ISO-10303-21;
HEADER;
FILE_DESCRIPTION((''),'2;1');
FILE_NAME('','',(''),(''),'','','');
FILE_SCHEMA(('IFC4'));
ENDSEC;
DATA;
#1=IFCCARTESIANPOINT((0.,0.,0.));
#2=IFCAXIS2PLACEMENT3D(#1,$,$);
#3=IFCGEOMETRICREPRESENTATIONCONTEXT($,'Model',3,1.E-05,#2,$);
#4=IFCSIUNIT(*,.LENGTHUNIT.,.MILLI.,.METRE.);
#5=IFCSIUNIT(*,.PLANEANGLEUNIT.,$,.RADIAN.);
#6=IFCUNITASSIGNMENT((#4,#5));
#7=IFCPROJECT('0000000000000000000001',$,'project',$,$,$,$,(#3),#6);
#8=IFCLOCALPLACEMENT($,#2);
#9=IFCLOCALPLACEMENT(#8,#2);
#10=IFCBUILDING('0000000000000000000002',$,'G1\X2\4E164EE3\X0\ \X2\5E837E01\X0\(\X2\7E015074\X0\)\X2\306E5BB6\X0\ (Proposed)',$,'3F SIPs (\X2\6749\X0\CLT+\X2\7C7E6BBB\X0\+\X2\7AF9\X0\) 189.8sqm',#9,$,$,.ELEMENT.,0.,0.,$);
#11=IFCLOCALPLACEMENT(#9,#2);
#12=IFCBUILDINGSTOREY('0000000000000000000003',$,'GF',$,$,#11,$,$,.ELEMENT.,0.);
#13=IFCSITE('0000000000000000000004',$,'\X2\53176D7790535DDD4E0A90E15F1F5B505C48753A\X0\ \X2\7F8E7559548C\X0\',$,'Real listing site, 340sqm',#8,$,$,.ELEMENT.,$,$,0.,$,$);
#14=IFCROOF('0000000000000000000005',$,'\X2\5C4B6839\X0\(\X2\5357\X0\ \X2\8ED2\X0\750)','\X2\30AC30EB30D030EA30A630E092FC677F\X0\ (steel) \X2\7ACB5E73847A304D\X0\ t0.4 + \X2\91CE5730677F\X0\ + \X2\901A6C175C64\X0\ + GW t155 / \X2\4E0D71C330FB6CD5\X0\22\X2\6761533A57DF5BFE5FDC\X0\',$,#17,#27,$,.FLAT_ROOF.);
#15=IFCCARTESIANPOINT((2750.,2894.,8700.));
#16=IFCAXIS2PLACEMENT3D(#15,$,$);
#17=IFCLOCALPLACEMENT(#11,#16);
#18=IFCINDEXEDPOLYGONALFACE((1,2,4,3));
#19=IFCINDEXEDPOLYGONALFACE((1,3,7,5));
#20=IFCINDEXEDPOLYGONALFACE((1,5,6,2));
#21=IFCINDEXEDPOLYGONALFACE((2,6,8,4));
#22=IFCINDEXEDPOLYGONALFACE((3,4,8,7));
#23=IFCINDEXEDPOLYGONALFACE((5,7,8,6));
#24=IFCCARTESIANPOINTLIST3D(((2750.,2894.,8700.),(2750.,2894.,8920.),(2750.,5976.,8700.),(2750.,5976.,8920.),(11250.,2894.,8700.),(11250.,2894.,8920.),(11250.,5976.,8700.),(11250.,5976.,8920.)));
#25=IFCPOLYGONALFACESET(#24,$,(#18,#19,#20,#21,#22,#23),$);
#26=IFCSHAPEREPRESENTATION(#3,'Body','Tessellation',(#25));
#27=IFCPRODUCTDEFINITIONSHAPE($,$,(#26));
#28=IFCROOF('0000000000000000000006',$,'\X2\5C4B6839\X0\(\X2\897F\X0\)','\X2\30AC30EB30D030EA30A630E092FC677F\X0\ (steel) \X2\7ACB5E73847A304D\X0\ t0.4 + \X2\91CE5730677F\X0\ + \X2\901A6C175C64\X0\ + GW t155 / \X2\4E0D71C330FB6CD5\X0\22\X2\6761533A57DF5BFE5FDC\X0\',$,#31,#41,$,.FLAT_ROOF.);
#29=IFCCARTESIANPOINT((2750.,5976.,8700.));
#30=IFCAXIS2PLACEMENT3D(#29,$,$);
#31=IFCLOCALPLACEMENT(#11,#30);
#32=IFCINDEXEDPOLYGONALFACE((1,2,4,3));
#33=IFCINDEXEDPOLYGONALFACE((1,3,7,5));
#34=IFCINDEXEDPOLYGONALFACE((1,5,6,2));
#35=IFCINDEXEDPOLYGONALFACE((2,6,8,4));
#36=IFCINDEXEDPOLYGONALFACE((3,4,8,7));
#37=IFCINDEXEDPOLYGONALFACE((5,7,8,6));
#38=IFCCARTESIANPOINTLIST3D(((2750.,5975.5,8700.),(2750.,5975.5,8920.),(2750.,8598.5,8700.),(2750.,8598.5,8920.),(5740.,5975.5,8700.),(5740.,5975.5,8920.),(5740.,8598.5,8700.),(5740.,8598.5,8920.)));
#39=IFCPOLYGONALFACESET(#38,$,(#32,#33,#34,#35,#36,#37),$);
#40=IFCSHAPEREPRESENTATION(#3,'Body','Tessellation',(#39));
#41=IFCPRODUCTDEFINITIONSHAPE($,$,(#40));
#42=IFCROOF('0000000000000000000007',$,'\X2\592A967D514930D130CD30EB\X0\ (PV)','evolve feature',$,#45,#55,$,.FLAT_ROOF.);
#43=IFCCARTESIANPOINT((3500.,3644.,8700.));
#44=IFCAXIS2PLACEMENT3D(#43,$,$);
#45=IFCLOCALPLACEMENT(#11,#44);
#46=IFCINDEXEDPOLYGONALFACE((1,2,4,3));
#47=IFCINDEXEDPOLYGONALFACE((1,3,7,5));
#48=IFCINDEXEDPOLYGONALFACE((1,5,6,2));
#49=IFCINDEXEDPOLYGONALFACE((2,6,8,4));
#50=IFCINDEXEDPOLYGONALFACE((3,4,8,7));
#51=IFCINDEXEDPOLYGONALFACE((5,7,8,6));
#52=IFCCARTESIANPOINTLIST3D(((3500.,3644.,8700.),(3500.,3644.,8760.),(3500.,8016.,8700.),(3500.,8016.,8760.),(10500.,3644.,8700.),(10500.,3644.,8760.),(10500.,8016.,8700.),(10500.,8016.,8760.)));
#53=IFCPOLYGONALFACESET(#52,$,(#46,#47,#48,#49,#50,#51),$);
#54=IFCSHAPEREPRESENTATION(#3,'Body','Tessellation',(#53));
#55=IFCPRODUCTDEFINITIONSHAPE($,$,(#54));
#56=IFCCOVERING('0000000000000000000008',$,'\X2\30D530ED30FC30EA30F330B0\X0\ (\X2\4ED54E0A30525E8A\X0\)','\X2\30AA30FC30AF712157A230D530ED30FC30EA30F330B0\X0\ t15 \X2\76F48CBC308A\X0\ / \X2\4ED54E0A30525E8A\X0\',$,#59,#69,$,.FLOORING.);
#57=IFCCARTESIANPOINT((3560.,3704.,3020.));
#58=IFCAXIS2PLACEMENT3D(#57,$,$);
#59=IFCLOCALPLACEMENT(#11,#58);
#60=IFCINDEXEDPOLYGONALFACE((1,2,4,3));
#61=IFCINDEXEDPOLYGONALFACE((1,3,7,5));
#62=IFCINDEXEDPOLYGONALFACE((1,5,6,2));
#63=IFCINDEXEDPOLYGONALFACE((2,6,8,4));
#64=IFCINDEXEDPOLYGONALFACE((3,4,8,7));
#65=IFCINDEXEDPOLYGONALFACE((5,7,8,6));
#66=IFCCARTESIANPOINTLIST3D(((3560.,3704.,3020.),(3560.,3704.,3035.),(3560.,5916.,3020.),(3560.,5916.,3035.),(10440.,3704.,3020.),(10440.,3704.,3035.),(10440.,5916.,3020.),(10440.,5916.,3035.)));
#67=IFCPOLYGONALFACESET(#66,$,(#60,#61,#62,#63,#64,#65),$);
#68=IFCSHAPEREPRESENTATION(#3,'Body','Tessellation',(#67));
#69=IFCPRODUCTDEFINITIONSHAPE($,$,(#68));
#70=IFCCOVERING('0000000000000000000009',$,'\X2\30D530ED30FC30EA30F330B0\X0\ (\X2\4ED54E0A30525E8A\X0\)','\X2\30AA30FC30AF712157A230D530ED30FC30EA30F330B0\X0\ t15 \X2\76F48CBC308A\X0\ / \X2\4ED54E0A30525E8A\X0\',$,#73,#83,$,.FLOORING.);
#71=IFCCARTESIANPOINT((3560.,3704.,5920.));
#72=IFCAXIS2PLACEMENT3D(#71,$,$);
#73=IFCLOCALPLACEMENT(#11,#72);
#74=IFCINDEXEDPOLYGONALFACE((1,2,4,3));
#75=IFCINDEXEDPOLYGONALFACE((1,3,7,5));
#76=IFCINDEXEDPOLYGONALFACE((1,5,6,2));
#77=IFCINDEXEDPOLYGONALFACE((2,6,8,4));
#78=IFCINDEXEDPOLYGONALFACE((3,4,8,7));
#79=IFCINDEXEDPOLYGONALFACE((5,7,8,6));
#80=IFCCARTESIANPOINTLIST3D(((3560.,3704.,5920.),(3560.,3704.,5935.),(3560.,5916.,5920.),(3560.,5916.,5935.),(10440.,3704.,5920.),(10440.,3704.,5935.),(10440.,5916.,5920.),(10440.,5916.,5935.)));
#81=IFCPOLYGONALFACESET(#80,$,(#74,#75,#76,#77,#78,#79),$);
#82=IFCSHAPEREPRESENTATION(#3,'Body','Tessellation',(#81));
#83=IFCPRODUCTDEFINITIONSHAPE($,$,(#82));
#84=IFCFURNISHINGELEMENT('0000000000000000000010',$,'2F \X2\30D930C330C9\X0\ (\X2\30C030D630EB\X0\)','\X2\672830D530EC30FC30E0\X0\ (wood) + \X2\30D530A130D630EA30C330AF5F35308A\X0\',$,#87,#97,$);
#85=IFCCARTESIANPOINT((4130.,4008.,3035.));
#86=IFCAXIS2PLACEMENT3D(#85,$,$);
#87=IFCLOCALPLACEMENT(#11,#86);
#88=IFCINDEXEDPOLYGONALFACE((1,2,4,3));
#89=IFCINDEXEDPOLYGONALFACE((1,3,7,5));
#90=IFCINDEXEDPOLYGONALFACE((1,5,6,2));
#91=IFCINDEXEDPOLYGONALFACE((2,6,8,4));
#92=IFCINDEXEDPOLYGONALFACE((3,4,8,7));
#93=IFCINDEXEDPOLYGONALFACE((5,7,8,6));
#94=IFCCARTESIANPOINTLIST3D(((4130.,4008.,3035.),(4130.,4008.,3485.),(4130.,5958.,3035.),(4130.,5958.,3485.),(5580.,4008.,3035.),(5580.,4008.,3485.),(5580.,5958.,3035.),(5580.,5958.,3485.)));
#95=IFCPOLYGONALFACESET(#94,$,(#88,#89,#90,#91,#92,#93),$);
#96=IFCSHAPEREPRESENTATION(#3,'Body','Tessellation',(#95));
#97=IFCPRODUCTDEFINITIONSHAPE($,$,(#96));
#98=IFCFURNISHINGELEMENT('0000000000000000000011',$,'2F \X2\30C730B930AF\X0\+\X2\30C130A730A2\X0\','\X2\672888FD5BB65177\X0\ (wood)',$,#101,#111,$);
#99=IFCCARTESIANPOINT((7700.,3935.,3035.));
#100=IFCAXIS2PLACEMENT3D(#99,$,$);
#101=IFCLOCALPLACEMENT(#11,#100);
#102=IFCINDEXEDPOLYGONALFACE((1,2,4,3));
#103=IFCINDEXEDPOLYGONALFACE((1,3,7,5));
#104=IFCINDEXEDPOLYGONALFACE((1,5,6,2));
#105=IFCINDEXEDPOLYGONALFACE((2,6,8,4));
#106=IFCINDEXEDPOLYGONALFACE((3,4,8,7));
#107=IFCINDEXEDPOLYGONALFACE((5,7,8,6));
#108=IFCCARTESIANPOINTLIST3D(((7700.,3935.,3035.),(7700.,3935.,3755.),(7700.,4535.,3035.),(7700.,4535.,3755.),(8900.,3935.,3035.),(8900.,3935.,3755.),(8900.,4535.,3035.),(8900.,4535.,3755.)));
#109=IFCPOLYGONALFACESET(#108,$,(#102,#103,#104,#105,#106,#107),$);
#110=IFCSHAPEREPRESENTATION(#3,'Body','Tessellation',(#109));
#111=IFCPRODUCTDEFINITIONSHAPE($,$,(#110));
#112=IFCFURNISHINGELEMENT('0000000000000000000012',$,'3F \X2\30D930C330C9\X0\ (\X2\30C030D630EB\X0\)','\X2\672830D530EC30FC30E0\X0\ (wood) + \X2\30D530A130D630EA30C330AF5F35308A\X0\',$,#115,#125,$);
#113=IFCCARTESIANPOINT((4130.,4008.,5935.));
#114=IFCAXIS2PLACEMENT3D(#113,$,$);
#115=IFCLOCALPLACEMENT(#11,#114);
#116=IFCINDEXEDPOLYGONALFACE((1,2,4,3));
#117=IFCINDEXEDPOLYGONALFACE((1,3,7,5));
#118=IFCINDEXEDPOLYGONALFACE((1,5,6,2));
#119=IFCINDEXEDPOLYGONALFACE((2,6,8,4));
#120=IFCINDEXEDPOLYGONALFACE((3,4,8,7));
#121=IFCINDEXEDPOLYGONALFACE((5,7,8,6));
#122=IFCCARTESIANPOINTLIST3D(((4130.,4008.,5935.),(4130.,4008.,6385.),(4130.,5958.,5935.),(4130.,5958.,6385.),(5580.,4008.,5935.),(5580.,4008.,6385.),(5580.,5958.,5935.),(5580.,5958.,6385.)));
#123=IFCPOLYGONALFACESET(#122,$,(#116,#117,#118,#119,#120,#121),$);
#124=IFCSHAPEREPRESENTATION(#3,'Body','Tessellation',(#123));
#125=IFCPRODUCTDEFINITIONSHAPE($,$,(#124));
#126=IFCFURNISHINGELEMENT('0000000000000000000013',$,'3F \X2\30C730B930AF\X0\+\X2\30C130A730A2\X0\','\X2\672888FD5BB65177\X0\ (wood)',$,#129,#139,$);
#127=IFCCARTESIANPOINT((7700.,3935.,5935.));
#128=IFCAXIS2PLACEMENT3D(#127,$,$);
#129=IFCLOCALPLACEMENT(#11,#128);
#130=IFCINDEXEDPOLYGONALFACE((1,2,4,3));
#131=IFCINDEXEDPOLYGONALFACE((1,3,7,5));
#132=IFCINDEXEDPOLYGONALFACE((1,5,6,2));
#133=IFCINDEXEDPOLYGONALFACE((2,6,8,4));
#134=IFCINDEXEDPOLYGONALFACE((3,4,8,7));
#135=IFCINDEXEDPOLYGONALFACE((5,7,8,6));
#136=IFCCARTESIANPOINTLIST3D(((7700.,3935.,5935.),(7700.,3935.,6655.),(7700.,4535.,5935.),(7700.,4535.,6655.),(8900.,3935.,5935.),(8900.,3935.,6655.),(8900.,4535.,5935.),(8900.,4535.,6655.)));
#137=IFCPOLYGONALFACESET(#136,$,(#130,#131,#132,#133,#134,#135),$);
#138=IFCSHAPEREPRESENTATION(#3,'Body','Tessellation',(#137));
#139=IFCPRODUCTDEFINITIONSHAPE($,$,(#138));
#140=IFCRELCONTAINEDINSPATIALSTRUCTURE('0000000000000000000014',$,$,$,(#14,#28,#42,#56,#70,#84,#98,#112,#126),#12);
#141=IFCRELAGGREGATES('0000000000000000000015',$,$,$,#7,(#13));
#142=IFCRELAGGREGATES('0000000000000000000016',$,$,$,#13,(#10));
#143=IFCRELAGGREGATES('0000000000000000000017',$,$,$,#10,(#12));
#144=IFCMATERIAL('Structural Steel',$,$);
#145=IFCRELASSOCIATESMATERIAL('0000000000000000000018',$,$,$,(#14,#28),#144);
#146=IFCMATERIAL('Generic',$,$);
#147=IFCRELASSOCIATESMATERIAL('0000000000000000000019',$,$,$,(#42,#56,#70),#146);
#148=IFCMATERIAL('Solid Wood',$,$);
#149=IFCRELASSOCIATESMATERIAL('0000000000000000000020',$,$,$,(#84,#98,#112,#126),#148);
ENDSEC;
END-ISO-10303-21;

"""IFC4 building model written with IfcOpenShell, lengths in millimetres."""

from ifc_helpers import new_model, si_unit, frame, frame_2d, origin, place, context, project, spatial, rectangle, extrude, material, element, save


model = new_model("IFC4")

# Units and contexts
model_context = context("Model", 3, precision=1e-05, world=origin())
ifc_project = project(units=[si_unit("LENGTHUNIT", "METRE", prefix="MILLI"), si_unit("PLANEANGLEUNIT", "RADIAN")], contexts=[model_context])

# Site, building, storey
site_placement = place(None, origin())
site = spatial("IfcSite", under=ifc_project, at=site_placement, Name="北海道川上郡弟子屈町 美留和", ObjectType="Real listing site, 340sqm", CompositionType="ELEMENT", RefElevation=0.0)
building_placement = place(site_placement, origin())
building = spatial("IfcBuilding", under=site, at=building_placement, Name="G1世代 広縁(縁側)の家 (Proposed)", ObjectType="3F SIPs (杉CLT+籾殻+竹) 189.8sqm", CompositionType="ELEMENT", ElevationOfRefHeight=0.0, ElevationOfTerrain=0.0)
storey_placement = place(building_placement, origin())
storey = spatial("IfcBuildingStorey", under=building, at=storey_placement, Name="GF", CompositionType="ELEMENT", Elevation=0.0)

# Shared definitions
ifc_material_1 = material(Name="Solid Wood")

# Roofs
ifc_material_2 = material(Name="Structural Steel")
roof_1_placement = place(storey_placement, frame((2750.0, 2894.0, 8700.0)))
element("IfcRoof", 1, at=roof_1_placement, inside=storey, material=ifc_material_2, Name="屋根(南 軒750)", Description="ガルバリウム鋼板 (steel) 立平葺き t0.4 + 野地板 + 通気層 + GW t155 / 不燃・法22条区域対応", PredefinedType="FLAT_ROOF", context=model_context, shape_type="SweptSolid", body=[
    extrude(rectangle(XDim=8500.0, YDim=3082.0, at=frame_2d((4250.0, 1541.0))), frame((2750.0, 2894.0, 8700.0)), (0.0, 0.0, 1.0), 220.0),
])
roof_2_placement = place(storey_placement, frame((2750.0, 5976.0, 8700.0)))
element("IfcRoof", 2, at=roof_2_placement, inside=storey, material=ifc_material_2, Name="屋根(西)", Description="ガルバリウム鋼板 (steel) 立平葺き t0.4 + 野地板 + 通気層 + GW t155 / 不燃・法22条区域対応", PredefinedType="FLAT_ROOF", context=model_context, shape_type="SweptSolid", body=[
    extrude(rectangle(XDim=2990.0, YDim=2623.0, at=frame_2d((1495.0, 1311.0))), frame((2750.0, 5976.0, 8700.0)), (0.0, 0.0, 1.0), 220.0),
])
ifc_material_3 = material(Name="Generic")
roof_3_placement = place(storey_placement, frame((3500.0, 3644.0, 8700.0)))
element("IfcRoof", 3, at=roof_3_placement, inside=storey, material=ifc_material_3, Name="太陽光パネル (PV)", Description="evolve feature", PredefinedType="FLAT_ROOF", context=model_context, shape_type="SweptSolid", body=[
    extrude(rectangle(XDim=7000.0, YDim=4372.0, at=frame_2d((3500.0, 2186.0))), frame((3500.0, 3644.0, 8700.0)), (0.0, 0.0, 1.0), 60.0),
])

# Coverings
covering_1_placement = place(storey_placement, frame((3560.0, 3704.0, 3020.0)))
element("IfcCovering", 4, at=covering_1_placement, inside=storey, material=ifc_material_3, Name="フローリング (仕上げ床)", Description="オーク無垢フローリング t15 直貼り / 仕上げ床", PredefinedType="FLOORING", context=model_context, shape_type="SweptSolid", body=[
    extrude(rectangle(XDim=6880.0, YDim=2212.0, at=frame_2d((3440.0, 1106.0))), frame((3560.0, 3704.0, 3020.0)), (0.0, 0.0, 1.0), 15.0),
])
covering_2_placement = place(storey_placement, frame((3560.0, 3704.0, 5920.0)))
element("IfcCovering", 5, at=covering_2_placement, inside=storey, material=ifc_material_3, Name="フローリング (仕上げ床)", Description="オーク無垢フローリング t15 直貼り / 仕上げ床", PredefinedType="FLOORING", context=model_context, shape_type="SweptSolid", body=[
    extrude(rectangle(XDim=6880.0, YDim=2212.0, at=frame_2d((3440.0, 1106.0))), frame((3560.0, 3704.0, 5920.0)), (0.0, 0.0, 1.0), 15.0),
])

# Furnishing elements
furnishing_1_placement = place(storey_placement, frame((4130.0, 4008.0, 3035.0)))
element("IfcFurnishingElement", 6, at=furnishing_1_placement, inside=storey, material=ifc_material_1, Name="2F ベッド (ダブル)", Description="木フレーム (wood) + ファブリック張り", context=model_context, shape_type="SweptSolid", body=[
    extrude(rectangle(XDim=1450.0, YDim=1950.0, at=frame_2d((725.0, 975.0))), frame((4130.0, 4008.0, 3035.0)), (0.0, 0.0, 1.0), 450.0),
])
furnishing_2_placement = place(storey_placement, frame((7700.0, 3935.0, 3035.0)))
element("IfcFurnishingElement", 7, at=furnishing_2_placement, inside=storey, material=ifc_material_1, Name="2F デスク+チェア", Description="木製家具 (wood)", context=model_context, shape_type="SweptSolid", body=[
    extrude(rectangle(XDim=1200.0, YDim=600.0, at=frame_2d((600.0, 300.0))), frame((7700.0, 3935.0, 3035.0)), (0.0, 0.0, 1.0), 720.0),
])
furnishing_3_placement = place(storey_placement, frame((4130.0, 4008.0, 5935.0)))
element("IfcFurnishingElement", 8, at=furnishing_3_placement, inside=storey, material=ifc_material_1, Name="3F ベッド (ダブル)", Description="木フレーム (wood) + ファブリック張り", context=model_context, shape_type="SweptSolid", body=[
    extrude(rectangle(XDim=1450.0, YDim=1950.0, at=frame_2d((725.0, 975.0))), frame((4130.0, 4008.0, 5935.0)), (0.0, 0.0, 1.0), 450.0),
])
furnishing_4_placement = place(storey_placement, frame((7700.0, 3935.0, 5935.0)))
element("IfcFurnishingElement", 9, at=furnishing_4_placement, inside=storey, material=ifc_material_1, Name="3F デスク+チェア", Description="木製家具 (wood)", context=model_context, shape_type="SweptSolid", body=[
    extrude(rectangle(XDim=1200.0, YDim=600.0, at=frame_2d((600.0, 300.0))), frame((7700.0, 3935.0, 5935.0)), (0.0, 0.0, 1.0), 720.0),
])

save(model, "model.ifc")
